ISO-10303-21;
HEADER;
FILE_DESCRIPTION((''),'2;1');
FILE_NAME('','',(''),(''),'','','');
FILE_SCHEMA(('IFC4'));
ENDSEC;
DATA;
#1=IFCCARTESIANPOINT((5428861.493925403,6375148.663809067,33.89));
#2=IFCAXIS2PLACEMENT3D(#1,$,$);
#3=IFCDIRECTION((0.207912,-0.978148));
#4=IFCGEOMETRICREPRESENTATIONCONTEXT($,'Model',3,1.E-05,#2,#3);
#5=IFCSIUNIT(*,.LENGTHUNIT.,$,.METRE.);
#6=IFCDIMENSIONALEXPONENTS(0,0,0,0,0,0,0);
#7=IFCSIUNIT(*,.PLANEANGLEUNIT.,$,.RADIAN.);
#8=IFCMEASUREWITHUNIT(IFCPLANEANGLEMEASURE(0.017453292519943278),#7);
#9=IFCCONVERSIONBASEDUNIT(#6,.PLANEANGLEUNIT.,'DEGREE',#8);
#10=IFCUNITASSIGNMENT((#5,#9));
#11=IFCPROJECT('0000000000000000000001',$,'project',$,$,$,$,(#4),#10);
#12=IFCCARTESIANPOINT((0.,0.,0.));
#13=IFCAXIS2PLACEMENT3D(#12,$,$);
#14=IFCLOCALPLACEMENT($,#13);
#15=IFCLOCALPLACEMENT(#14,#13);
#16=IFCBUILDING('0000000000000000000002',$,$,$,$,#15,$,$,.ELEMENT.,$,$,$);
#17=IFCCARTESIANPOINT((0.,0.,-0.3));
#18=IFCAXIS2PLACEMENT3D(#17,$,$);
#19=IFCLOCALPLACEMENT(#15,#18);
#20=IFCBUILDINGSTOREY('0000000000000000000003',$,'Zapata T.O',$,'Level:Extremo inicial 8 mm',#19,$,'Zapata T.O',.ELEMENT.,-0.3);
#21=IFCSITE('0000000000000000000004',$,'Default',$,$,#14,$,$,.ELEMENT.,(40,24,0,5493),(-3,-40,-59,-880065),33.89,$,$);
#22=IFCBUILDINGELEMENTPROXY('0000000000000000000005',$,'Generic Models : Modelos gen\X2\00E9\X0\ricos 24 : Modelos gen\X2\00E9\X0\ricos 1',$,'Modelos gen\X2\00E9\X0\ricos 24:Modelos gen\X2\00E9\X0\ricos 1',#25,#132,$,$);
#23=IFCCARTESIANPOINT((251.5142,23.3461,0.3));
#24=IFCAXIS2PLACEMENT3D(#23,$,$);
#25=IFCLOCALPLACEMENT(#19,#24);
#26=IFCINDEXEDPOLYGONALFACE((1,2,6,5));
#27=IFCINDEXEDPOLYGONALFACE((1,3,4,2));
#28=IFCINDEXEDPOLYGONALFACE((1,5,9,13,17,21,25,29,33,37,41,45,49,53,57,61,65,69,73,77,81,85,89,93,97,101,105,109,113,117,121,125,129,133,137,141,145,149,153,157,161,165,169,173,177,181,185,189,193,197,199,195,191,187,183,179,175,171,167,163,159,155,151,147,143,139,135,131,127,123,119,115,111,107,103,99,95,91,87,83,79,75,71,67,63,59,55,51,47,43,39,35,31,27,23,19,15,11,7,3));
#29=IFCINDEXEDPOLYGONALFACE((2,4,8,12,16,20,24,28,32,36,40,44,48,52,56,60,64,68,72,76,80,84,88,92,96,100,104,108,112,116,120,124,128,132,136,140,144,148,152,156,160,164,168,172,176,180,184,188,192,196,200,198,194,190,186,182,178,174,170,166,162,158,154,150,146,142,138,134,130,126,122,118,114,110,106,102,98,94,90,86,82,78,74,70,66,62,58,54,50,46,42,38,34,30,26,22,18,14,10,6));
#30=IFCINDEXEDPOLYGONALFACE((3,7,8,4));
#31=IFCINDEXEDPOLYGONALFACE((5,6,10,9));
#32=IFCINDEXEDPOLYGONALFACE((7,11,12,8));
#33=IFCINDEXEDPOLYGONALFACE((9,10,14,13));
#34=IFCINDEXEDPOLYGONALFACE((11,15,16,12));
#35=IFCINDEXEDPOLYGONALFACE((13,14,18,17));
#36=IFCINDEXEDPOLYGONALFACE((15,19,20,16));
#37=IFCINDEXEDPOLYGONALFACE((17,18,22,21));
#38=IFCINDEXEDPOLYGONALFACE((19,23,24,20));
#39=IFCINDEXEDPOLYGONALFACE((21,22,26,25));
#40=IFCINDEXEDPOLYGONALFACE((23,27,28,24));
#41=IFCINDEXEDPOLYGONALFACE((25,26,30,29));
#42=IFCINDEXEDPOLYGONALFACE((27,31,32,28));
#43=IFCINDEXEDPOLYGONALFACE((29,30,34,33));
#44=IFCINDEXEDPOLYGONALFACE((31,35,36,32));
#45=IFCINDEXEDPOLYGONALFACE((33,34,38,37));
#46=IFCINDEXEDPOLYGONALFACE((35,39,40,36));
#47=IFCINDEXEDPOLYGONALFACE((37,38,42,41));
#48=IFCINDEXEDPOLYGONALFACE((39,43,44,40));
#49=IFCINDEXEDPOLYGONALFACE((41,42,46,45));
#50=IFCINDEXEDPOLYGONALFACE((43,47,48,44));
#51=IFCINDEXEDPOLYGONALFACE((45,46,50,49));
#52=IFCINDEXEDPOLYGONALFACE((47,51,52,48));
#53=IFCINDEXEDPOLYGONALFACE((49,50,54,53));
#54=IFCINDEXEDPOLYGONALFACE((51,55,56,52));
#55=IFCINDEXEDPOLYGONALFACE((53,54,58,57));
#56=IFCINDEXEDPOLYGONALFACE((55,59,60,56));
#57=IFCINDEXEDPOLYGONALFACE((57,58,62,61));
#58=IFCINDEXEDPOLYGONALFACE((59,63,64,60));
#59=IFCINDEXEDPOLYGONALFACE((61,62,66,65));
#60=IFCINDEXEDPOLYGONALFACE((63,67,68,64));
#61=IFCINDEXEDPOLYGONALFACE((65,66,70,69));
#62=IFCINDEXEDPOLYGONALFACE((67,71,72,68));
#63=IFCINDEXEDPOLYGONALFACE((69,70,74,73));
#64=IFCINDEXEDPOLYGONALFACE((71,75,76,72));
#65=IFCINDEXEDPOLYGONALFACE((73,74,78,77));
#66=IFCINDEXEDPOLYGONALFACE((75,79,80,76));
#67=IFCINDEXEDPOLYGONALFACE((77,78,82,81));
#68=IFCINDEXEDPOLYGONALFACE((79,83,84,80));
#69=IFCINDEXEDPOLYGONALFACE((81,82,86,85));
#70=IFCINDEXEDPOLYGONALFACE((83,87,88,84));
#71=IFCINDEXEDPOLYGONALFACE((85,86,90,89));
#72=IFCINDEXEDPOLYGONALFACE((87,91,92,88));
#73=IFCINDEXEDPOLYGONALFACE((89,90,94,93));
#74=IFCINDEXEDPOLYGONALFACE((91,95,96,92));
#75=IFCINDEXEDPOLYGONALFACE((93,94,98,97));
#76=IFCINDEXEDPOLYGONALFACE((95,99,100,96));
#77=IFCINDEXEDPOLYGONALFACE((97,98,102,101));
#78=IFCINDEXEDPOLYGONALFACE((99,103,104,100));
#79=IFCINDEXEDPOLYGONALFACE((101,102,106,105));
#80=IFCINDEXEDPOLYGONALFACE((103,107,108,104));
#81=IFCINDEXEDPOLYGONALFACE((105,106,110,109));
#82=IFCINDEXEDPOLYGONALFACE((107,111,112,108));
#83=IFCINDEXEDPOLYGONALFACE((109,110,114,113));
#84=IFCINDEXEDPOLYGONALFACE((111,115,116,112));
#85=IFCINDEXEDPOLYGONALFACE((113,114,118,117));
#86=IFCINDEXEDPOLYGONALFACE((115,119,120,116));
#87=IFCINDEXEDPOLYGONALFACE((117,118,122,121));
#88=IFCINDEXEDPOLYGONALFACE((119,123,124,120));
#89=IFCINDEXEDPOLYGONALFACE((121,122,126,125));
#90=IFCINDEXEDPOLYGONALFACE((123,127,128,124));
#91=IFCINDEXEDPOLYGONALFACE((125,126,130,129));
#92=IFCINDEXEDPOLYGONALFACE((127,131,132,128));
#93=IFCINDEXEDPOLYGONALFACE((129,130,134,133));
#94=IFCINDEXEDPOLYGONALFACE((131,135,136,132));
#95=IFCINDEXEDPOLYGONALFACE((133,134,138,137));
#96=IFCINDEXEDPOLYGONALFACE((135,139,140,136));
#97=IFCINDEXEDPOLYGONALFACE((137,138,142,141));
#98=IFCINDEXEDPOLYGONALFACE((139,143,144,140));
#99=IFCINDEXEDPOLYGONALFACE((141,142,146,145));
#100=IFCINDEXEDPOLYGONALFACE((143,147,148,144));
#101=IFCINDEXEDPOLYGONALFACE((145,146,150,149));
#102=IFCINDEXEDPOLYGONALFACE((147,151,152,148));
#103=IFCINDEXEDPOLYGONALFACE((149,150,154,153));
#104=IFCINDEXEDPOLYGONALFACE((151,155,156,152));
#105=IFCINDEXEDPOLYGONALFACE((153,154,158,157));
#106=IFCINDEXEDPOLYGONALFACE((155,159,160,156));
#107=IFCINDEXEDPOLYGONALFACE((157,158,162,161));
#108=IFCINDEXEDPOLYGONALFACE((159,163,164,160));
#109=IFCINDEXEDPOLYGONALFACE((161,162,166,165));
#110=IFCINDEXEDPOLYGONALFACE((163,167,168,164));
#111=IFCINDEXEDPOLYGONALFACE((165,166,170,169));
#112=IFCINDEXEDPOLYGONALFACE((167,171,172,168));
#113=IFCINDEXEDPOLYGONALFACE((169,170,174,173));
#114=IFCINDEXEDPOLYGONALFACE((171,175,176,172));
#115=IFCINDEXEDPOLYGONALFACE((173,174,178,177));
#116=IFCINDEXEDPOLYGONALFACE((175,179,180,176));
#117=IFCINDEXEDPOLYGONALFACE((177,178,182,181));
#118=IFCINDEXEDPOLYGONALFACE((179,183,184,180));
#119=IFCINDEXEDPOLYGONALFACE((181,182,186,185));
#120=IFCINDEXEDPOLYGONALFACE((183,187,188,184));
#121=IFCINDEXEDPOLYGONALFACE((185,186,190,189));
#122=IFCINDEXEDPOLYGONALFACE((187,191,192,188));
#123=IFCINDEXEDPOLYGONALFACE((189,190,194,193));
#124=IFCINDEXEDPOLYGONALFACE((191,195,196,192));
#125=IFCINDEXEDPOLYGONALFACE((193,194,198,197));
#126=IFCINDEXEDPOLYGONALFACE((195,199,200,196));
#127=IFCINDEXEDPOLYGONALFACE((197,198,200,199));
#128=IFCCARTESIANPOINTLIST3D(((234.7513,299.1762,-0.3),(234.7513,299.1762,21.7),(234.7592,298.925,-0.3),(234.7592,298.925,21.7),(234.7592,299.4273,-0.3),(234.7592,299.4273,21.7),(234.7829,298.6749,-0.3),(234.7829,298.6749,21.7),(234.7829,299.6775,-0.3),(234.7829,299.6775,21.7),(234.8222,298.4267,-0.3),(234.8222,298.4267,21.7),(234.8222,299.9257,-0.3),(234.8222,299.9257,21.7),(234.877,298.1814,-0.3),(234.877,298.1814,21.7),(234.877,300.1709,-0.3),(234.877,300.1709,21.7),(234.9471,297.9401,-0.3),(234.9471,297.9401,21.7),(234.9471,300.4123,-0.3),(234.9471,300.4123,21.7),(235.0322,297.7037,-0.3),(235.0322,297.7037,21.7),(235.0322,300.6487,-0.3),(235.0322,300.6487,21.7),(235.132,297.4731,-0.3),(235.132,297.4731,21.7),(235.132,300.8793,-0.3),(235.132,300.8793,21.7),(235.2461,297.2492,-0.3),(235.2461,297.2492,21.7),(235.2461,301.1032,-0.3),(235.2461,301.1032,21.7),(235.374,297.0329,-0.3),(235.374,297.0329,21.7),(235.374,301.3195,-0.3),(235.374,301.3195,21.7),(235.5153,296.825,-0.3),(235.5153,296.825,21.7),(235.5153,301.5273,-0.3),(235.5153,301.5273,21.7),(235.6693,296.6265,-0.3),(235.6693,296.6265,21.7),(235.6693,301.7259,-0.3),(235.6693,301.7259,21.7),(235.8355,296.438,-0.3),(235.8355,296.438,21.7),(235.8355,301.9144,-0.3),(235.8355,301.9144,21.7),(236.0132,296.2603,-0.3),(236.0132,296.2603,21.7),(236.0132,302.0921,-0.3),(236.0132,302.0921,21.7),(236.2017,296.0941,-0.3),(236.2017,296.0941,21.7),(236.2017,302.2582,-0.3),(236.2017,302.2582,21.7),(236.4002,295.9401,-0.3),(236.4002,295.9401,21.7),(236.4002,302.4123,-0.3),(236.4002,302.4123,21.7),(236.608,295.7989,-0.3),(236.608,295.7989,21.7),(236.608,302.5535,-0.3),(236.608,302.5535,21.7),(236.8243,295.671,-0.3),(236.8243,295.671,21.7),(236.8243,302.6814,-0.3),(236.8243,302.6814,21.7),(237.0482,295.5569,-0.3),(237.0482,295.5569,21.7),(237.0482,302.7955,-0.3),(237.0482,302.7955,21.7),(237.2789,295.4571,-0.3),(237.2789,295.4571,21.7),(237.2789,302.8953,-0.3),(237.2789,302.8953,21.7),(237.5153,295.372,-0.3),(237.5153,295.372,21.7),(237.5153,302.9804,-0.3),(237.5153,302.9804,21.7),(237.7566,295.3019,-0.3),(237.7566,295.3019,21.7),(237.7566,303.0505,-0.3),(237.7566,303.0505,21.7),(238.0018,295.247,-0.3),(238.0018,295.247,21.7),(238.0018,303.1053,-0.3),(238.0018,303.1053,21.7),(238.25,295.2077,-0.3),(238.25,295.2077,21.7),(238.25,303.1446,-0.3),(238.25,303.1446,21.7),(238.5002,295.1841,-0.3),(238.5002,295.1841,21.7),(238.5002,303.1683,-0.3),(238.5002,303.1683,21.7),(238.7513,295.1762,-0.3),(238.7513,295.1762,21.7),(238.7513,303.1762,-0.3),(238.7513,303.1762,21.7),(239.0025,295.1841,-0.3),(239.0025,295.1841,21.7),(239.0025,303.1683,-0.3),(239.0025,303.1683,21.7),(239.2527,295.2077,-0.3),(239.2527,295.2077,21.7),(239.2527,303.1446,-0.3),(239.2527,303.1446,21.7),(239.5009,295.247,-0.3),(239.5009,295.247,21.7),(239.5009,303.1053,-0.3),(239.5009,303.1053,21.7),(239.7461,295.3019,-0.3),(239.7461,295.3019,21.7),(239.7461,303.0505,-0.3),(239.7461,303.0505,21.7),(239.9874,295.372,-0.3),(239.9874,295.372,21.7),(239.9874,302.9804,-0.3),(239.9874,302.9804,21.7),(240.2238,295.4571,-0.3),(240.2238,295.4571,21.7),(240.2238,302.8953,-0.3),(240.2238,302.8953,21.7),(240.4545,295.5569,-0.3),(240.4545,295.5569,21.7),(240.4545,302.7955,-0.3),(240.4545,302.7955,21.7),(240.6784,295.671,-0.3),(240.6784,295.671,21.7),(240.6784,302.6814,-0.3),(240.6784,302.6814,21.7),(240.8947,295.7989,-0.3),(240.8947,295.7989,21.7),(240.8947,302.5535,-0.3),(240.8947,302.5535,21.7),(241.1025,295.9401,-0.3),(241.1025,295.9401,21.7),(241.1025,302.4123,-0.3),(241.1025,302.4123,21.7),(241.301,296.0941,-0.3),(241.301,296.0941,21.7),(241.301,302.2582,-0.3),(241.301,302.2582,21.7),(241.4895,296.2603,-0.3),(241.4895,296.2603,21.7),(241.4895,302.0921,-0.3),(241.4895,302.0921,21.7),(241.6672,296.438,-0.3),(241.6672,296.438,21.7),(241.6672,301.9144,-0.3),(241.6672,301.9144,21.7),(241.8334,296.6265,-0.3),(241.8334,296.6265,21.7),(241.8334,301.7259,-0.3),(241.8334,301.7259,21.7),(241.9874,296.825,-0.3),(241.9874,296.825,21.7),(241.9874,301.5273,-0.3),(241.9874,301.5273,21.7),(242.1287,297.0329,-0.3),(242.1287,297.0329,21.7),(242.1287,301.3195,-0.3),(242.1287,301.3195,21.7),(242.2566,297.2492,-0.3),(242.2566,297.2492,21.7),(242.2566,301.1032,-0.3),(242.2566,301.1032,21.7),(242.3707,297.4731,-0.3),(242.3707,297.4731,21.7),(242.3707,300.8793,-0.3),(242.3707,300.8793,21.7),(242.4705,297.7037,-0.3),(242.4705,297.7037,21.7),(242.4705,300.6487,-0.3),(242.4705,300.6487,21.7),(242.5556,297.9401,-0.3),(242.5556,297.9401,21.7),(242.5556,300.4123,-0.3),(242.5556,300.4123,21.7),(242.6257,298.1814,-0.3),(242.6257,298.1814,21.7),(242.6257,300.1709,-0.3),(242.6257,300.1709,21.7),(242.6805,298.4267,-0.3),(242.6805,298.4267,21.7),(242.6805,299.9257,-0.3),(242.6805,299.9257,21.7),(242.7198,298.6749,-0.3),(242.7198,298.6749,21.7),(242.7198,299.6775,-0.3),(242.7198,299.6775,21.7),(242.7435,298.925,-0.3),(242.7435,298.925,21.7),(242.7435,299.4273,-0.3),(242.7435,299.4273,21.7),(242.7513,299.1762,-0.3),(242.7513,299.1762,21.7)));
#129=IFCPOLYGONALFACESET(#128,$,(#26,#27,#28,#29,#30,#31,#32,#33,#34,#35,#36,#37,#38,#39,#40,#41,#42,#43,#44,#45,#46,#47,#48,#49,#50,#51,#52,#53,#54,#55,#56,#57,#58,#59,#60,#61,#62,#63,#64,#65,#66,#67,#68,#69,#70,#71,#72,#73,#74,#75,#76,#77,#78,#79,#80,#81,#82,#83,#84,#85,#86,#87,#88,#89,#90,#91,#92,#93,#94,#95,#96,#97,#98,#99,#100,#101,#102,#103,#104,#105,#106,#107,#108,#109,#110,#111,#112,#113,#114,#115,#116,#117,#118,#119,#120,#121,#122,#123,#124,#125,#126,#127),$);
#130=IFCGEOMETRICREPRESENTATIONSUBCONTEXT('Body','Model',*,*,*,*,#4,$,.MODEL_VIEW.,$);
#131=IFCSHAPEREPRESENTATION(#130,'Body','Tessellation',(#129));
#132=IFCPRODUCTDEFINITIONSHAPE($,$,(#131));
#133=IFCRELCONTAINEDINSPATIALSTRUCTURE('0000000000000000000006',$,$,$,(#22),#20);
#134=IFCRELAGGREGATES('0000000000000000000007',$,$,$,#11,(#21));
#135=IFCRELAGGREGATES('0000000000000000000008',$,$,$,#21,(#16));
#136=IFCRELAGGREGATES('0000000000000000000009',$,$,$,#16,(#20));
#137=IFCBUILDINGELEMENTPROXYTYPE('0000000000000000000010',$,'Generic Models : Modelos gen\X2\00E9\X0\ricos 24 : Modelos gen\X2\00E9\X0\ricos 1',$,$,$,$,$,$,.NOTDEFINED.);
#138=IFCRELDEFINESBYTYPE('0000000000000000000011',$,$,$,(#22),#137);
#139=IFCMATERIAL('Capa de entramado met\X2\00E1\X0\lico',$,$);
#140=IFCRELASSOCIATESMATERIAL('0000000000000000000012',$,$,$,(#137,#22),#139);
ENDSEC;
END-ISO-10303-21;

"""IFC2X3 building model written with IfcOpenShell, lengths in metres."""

from ifc_helpers import new_model, entity, si_unit, converted_unit, direction, frame, origin, origin_2d_with_axis, place, context, subcontext, project, spatial, circle, extrude, source, transform, mapped, material, type_object, type_shapes, element, save


model = new_model("IFC2X3")

# Units and contexts
model_context = context("Model", 3, precision=1e-05, world=frame((5428861.493925403, 6375148.663809067, 33.89)), true_north=direction((0.207912, -0.978148)))
body_context = subcontext(model_context, "Body", "Model", "MODEL_VIEW")
ifc_project = project(units=[si_unit("LENGTHUNIT", "METRE"), converted_unit("PLANEANGLEUNIT", "DEGREE", entity("IfcPlaneAngleMeasure", 0.017453292519943278), si_unit("PLANEANGLEUNIT", "RADIAN"), dimensions=[0, 0, 0, 0, 0, 0, 0])], contexts=[model_context])

# Site, building, storey
site_placement = place(None, origin())
site = spatial("IfcSite", under=ifc_project, at=site_placement, Name="Default", CompositionType="ELEMENT", RefLatitude=(40, 24, 0, 5493), RefLongitude=(-3, -40, -59, -880065), RefElevation=33.89)
building_placement = place(site_placement, origin())
building = spatial("IfcBuilding", under=site, at=building_placement, CompositionType="ELEMENT")
storey_placement = place(building_placement, frame((0.0, 0.0, -0.3)))
storey = spatial("IfcBuildingStorey", under=building, at=storey_placement, Name="Zapata T.O", ObjectType="Level:Extremo inicial 8 mm", LongName="Zapata T.O", CompositionType="ELEMENT", Elevation=-0.3)

# Building element proxy
ifc_material = material(Name="Capa de entramado metálico")
building_element_proxy_type_1 = type_object("IfcBuildingElementProxyType", Name="Generic Models : Modelos genéricos 24 : Modelos genéricos 1", PredefinedType="NOTDEFINED", material=ifc_material)
shared_shape_1 = source(origin(), body_context, "Body", "SweptSolid", [
    extrude(circle(Radius=4.0, at=origin_2d_with_axis()), frame((238.7513, 299.1762, -0.3)), (0.0, 0.0, 1.0), 22.0),
])
type_shapes(building_element_proxy_type_1, [shared_shape_1])
proxy_1_placement = place(storey_placement, frame((251.5142, 23.3461, 0.3)))
element("IfcBuildingElementProxy", 1, at=proxy_1_placement, inside=storey, type_object=building_element_proxy_type_1, material=ifc_material, Name="Generic Models : Modelos genéricos 24 : Modelos genéricos 1", ObjectType="Modelos genéricos 24:Modelos genéricos 1", context=body_context, shape_type="MappedRepresentation", body=[
    mapped(shared_shape_1, transform((0.0, 0.0, 0.0), scale=1.0)),
])

save(model, "model.ifc")
